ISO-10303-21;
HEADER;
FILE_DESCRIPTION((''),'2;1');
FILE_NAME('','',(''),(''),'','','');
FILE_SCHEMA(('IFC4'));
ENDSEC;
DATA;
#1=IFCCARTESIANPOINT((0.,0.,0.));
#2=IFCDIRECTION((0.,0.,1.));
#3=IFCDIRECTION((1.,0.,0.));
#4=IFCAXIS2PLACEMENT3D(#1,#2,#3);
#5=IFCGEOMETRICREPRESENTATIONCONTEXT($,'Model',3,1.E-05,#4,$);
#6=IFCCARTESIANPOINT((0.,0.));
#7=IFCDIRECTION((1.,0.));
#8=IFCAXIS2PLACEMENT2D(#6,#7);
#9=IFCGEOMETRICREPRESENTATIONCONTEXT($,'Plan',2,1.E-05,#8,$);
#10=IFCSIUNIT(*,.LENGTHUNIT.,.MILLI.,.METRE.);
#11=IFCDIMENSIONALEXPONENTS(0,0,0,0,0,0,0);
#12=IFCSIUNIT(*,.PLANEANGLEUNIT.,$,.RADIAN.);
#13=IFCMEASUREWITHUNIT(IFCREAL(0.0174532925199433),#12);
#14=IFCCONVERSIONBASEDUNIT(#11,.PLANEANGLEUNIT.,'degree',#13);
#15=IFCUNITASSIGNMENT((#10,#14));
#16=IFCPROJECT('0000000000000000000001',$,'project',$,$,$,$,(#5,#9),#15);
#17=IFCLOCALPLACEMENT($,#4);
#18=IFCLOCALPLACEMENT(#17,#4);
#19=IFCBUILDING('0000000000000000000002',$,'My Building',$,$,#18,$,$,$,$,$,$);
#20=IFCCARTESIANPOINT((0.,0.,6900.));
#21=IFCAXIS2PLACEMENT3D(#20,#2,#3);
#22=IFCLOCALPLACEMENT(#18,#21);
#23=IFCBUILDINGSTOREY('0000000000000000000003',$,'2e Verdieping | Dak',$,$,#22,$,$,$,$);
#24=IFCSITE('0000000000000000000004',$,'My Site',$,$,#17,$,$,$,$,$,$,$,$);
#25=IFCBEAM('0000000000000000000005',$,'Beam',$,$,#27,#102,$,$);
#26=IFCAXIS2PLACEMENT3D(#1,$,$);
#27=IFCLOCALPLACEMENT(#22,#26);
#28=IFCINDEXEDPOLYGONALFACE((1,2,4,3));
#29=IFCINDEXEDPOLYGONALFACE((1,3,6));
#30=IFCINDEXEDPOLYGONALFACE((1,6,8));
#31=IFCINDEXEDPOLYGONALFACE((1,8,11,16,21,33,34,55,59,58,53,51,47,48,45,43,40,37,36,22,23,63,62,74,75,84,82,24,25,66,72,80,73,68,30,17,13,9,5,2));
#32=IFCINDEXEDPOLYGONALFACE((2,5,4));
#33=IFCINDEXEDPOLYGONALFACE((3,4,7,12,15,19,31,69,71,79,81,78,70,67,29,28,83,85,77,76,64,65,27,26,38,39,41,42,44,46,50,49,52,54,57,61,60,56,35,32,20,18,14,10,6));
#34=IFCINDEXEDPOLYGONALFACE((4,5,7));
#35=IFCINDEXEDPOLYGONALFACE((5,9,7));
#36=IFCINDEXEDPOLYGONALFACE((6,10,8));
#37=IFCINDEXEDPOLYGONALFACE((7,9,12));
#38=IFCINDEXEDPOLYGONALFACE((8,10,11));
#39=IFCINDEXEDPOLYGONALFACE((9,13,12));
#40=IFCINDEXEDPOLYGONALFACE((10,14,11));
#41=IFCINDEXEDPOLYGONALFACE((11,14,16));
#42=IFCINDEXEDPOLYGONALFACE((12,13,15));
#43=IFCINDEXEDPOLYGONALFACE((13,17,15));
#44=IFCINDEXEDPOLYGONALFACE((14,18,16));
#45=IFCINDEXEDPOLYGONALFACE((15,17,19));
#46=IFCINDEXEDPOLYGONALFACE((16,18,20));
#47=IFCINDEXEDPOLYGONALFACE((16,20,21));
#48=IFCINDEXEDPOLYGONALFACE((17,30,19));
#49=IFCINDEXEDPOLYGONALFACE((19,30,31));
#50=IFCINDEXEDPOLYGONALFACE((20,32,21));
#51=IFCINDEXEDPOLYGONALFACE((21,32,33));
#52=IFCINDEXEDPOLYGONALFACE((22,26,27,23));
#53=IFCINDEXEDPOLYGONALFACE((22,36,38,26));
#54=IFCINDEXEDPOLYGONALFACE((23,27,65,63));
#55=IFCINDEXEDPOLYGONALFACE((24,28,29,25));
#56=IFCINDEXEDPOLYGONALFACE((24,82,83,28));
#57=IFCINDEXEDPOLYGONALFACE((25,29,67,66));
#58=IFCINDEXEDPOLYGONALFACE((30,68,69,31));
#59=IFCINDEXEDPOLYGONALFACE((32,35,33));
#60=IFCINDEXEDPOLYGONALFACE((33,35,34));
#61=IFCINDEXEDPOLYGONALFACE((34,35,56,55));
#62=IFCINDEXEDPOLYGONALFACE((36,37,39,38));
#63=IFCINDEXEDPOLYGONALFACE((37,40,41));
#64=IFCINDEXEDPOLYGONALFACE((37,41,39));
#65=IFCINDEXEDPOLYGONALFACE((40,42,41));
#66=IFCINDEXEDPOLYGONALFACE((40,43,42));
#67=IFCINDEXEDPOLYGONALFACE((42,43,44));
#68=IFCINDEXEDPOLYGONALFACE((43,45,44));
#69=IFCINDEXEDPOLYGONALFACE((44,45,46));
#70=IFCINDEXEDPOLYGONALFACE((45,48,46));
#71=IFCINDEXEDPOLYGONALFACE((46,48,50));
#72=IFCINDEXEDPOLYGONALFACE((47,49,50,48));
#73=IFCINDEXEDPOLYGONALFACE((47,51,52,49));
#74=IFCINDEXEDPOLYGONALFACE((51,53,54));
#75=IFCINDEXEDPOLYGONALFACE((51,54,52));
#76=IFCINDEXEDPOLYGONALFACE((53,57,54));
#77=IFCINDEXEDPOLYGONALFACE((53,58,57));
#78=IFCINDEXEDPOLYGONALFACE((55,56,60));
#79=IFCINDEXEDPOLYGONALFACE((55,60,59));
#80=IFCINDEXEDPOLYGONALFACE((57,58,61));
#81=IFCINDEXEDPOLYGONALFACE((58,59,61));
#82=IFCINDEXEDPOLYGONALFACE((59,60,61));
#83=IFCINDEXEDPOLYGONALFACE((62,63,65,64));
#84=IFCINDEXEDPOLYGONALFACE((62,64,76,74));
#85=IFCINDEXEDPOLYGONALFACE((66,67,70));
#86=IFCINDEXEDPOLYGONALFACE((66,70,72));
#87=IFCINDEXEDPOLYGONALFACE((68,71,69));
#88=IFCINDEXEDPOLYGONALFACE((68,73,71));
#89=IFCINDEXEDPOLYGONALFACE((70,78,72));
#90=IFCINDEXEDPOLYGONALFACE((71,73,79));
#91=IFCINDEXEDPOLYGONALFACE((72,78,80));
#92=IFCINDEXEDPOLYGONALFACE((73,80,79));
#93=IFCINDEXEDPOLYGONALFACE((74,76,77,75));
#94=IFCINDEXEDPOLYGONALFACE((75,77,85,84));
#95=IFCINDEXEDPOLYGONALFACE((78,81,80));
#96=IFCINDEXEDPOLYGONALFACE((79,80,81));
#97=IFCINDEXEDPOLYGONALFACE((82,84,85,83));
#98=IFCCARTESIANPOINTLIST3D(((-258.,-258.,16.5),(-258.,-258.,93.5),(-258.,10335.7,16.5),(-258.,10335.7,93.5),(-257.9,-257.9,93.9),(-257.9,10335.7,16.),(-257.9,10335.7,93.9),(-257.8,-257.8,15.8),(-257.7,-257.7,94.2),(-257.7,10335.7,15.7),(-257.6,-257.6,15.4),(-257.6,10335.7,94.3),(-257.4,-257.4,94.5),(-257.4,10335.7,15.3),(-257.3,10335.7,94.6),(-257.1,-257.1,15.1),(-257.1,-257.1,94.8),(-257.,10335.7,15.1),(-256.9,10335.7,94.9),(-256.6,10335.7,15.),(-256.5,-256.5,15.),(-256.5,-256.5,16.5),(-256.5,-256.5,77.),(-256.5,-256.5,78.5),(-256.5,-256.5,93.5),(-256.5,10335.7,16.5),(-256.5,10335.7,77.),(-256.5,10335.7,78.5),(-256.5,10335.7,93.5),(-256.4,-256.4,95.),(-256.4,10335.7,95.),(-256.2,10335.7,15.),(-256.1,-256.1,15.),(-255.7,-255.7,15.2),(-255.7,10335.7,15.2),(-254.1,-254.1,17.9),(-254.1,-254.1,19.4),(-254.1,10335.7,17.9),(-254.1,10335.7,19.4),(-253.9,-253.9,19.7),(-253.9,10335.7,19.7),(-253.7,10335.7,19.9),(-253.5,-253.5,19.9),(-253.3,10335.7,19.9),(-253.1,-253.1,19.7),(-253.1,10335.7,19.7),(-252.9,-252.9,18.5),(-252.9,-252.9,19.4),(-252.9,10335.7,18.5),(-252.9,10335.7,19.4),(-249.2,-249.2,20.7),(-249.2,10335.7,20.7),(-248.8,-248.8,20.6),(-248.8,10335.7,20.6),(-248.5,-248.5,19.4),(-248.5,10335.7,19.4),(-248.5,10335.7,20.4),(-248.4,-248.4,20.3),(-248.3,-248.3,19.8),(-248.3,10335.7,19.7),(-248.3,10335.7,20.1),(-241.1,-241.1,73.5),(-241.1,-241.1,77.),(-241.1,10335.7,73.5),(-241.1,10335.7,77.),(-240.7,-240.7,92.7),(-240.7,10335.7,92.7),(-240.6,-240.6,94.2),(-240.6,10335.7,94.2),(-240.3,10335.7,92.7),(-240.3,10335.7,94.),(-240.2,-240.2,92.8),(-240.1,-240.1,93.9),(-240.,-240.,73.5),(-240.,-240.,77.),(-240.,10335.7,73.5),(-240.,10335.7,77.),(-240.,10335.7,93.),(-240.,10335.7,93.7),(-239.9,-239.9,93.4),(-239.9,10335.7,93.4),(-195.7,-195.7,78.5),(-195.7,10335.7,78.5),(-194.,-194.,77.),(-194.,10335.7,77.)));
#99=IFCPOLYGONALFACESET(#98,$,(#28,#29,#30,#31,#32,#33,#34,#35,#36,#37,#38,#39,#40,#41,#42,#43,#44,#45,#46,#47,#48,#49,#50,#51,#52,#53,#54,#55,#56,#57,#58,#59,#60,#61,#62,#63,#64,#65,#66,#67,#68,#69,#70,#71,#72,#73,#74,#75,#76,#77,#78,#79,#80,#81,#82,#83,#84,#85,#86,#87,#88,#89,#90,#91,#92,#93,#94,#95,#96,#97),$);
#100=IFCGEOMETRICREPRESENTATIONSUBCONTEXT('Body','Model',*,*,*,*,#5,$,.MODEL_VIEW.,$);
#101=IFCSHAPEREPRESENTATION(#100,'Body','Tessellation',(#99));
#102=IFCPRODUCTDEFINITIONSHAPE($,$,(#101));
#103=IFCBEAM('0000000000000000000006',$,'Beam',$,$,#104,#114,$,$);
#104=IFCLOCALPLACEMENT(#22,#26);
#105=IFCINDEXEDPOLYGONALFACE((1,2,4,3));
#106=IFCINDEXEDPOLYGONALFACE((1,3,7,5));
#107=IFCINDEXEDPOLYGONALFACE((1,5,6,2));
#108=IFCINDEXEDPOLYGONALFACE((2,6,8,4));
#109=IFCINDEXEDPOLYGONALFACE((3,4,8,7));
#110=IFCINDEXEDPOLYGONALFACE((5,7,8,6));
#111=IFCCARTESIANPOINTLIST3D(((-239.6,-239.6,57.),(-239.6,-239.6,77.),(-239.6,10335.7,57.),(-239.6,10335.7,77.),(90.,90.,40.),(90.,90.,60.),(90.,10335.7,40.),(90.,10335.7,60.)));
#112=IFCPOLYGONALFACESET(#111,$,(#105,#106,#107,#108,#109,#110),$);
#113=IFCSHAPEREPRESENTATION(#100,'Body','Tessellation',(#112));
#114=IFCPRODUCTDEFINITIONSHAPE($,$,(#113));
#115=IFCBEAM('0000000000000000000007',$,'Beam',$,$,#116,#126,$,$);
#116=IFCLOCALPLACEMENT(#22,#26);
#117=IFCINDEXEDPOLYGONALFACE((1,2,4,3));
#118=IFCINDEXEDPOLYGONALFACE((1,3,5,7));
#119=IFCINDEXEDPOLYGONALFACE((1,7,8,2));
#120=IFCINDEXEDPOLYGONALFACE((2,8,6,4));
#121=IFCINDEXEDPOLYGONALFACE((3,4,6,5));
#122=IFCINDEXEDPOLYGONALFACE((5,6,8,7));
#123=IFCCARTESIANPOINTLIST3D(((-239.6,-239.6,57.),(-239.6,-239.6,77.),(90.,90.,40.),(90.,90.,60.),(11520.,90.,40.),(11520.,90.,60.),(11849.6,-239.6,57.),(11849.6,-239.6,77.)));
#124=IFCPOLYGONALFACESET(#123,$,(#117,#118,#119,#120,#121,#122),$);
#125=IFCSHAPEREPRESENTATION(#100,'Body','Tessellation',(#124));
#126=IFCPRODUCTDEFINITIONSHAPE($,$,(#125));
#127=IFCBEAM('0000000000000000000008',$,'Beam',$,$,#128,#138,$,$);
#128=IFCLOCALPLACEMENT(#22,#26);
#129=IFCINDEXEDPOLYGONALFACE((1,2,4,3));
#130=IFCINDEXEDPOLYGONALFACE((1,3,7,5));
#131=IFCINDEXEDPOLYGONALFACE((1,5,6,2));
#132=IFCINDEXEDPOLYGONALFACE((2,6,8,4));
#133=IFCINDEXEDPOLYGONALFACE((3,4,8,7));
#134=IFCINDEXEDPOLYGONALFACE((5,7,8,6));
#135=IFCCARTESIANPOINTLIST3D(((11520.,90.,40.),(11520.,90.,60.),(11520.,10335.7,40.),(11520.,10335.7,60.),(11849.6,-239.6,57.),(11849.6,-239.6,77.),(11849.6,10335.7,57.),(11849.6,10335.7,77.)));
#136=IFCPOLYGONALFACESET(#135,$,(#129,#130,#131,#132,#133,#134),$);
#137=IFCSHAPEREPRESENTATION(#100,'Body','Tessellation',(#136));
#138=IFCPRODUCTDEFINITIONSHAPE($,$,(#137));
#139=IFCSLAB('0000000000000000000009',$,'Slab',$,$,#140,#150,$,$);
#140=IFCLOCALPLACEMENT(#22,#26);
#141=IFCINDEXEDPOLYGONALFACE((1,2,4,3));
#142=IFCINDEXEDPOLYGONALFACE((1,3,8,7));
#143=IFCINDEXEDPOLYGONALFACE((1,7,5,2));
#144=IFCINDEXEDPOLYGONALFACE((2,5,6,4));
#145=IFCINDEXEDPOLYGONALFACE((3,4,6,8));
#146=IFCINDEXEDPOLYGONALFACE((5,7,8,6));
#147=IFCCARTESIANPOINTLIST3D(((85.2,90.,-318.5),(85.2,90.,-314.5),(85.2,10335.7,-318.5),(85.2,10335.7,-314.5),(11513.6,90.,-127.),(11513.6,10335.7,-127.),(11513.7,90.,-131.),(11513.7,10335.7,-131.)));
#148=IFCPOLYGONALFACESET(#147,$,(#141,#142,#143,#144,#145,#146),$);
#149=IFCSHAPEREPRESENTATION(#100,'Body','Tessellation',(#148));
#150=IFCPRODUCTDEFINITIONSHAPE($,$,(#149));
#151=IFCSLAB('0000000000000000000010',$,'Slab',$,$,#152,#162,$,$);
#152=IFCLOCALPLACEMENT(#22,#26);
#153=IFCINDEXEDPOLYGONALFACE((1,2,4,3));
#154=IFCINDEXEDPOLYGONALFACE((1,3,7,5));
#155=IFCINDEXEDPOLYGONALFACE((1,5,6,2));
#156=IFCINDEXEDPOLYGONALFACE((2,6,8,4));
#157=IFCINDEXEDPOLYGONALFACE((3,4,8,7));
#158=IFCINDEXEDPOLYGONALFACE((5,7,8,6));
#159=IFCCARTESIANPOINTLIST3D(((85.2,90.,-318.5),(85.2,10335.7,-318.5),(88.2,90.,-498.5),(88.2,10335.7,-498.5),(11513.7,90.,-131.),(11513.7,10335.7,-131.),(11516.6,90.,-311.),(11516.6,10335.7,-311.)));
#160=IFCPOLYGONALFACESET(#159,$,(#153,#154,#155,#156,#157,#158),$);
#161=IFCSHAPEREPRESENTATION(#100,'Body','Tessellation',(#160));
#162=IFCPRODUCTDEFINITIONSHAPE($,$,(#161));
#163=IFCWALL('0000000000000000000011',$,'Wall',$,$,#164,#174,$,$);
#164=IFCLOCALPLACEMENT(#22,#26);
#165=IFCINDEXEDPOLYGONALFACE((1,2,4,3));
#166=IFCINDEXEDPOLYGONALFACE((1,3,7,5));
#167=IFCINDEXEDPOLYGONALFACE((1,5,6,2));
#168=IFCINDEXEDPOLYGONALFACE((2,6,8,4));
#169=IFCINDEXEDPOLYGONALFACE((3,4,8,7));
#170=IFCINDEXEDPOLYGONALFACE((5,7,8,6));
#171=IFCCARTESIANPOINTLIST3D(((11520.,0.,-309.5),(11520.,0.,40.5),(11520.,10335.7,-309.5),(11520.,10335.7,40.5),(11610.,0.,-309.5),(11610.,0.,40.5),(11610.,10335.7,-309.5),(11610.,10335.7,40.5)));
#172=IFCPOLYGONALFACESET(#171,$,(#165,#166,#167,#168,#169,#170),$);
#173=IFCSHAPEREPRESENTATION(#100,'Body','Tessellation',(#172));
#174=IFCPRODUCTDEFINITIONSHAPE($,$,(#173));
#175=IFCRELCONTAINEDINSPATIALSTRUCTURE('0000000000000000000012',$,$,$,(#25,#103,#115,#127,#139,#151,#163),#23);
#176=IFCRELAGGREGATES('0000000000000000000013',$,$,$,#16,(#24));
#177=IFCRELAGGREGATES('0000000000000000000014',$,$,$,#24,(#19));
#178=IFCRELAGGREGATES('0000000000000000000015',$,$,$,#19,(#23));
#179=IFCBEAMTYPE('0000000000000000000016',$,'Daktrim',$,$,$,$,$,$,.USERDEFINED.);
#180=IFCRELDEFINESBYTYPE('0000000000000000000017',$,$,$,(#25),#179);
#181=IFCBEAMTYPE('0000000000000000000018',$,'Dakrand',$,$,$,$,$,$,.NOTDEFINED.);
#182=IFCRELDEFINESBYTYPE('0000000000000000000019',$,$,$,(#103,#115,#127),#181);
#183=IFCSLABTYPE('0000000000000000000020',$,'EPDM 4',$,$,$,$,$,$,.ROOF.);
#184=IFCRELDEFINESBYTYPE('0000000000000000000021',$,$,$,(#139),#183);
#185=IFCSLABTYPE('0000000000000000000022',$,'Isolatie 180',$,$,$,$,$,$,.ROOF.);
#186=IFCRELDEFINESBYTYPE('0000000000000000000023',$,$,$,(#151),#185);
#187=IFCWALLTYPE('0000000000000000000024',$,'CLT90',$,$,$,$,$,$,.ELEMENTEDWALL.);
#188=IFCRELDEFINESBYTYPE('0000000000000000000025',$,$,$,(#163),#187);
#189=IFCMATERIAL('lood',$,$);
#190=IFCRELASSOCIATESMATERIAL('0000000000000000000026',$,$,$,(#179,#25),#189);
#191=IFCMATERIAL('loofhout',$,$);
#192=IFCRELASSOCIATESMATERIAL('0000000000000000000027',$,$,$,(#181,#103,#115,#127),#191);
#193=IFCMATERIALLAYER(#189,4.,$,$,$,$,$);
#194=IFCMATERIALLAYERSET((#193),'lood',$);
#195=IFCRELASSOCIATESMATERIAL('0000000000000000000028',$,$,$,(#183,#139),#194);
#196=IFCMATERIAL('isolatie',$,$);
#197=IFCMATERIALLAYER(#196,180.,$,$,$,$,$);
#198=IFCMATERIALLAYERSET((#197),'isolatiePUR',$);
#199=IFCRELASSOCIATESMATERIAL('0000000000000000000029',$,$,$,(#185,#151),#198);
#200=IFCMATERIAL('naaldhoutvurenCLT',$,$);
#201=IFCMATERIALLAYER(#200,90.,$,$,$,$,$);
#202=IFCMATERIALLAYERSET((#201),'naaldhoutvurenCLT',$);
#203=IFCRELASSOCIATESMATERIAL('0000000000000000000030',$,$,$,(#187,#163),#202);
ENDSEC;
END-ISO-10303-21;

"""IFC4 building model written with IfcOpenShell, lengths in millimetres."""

from ifc_helpers import new_model, entity, si_unit, converted_unit, frame, origin_with_axes, origin_2d_with_axis, place, context, subcontext, project, spatial, line, arc, indexed_curve, outline, extrude, clip, halfspace, material, layer, layer_set, layer_usage, material_profile, profile_set, profile_usage, type_object, element, save


model = new_model("IFC4")

# Units and contexts
model_context = context("Model", 3, precision=1e-05, world=origin_with_axes())
plan_context = context("Plan", 2, precision=1e-05, world=origin_2d_with_axis())
body_context = subcontext(model_context, "Body", "Model", "MODEL_VIEW")
ifc_project = project(units=[si_unit("LENGTHUNIT", "METRE", prefix="MILLI"), converted_unit("PLANEANGLEUNIT", "degree", entity("IfcReal", 0.0174532925199433), si_unit("PLANEANGLEUNIT", "RADIAN"), dimensions=[0, 0, 0, 0, 0, 0, 0])], contexts=[model_context, plan_context])

# Site, building, storey
site_placement = place(None, origin_with_axes())
site = spatial("IfcSite", under=ifc_project, at=site_placement, Name="My Site")
building_placement = place(site_placement, origin_with_axes())
building = spatial("IfcBuilding", under=site, at=building_placement, Name="My Building")
storey_placement = place(building_placement, frame((0.0, 0.0, 6900.0), z_axis=(0.0, 0.0, 1.0), x_axis=(1.0, 0.0, 0.0)))
storey = spatial("IfcBuildingStorey", under=building, at=storey_placement, Name="2e Verdieping | Dak")

# Beams
ifc_material_1 = material(Name="lood")
ifc_material_profile_1 = material_profile(ifc_material_1, outline(indexed_curve([(12.9, -58.5), (12.9, -57.6), (13.5, -57.1), (14.1, -57.6), (14.1, -59.1), (16.5, -60.5), (16.5, 0.0), (1.1, 0.0), (1.1, -3.5), (0.0, -3.5), (0.0, 0.0), (-46.0, 0.0), (-44.3, 1.5), (16.5, 1.5), (16.5, 16.5), (0.7, 15.7), (-0.1, 16.4), (0.6, 17.2), (16.4, 18.0), (17.6, 17.3), (18.0, 16.5), (18.0, -60.5), (17.2, -61.8), (15.8, -61.8), (8.5, -57.6), (8.4, -56.7), (9.2, -56.3)], segments=[line(10, 9), line(9, 8), line(8, 7), line(7, 6), line(6, 5), line(5, 4), arc(4, 3, 2), line(2, 1), line(1, 27), arc(27, 26, 25), line(25, 24), arc(24, 23, 22), line(22, 21), arc(21, 20, 19), line(19, 18), arc(18, 17, 16), line(16, 15), line(15, 14), line(14, 13), line(13, 12), line(12, 11), line(11, 10)], self_intersect=False)))
ifc_profile_set_1 = profile_set([ifc_material_profile_1], Name="lood")
beam_type_1 = type_object("IfcBeamType", Name="Daktrim", PredefinedType="USERDEFINED", material=ifc_profile_set_1)
ifc_profile_usage_1 = profile_usage(ifc_profile_set_1, cardinal=5)
beam_1_placement = place(storey_placement, frame((-240.0, -258.0, 77.0), z_axis=(0.0, 1.0, 0.0), x_axis=(-1.0, 0.0, 0.0)))
element("IfcBeam", 1, at=beam_1_placement, inside=storey, type_object=beam_type_1, material=ifc_profile_usage_1, Name="Beam", context=body_context, shape_type="Clipping", body=[
    clip(extrude(outline(indexed_curve([(12.9, -58.5), (12.9, -57.6), (13.5, -57.1), (14.1, -57.6), (14.1, -59.1), (16.5, -60.5), (16.5, 0.0), (1.1, 0.0), (1.1, -3.5), (0.0, -3.5), (0.0, 0.0), (-46.0, 0.0), (-44.3, 1.5), (16.5, 1.5), (16.5, 16.5), (0.7, 15.7), (-0.1, 16.4), (0.6, 17.2), (16.4, 18.0), (17.6, 17.3), (18.0, 16.5), (18.0, -60.5), (17.2, -61.8), (15.8, -61.8), (8.5, -57.6), (8.4, -56.7), (9.2, -56.3)], segments=[line(10, 9), line(9, 8), line(8, 7), line(7, 6), line(6, 5), line(5, 4), arc(4, 3, 2), line(2, 1), line(1, 27), arc(27, 26, 25), line(25, 24), arc(24, 23, 22), line(22, 21), arc(21, 20, 19), line(19, 18), arc(18, 17, 16), line(16, 15), line(15, 14), line(14, 13), line(13, 12), line(12, 11), line(11, 10)], self_intersect=False)), origin_with_axes(), (0.0, 0.0, 1.0), 10593.7), halfspace(frame((18.0, -6977.0, 0.0), z_axis=(-0.707107, 0.0, -0.707107), x_axis=(0.0, 1.0, 0.0)), False)),
])
ifc_material_2 = material(Name="loofhout")
ifc_material_profile_2 = material_profile(ifc_material_2, outline(indexed_curve([(329.6, 37.0), (329.6, 17.0), (0.0, 0.0), (0.0, 20.0)], segments=[line(3, 2), line(2, 1), line(1, 4), line(4, 3)], self_intersect=False)))
ifc_profile_set_2 = profile_set([ifc_material_profile_2], Name="loofhout")
ifc_profile_usage_2 = profile_usage(ifc_profile_set_2)
beam_type_2 = type_object("IfcBeamType", Name="Dakrand", PredefinedType="NOTDEFINED", material=ifc_profile_set_2)
beam_2_placement = place(storey_placement, frame((90.0, -239.6, 40.0), z_axis=(0.0, 1.0, 0.0), x_axis=(-1.0, 0.0, 0.0)))
element("IfcBeam", 2, at=beam_2_placement, inside=storey, type_object=beam_type_2, material=ifc_profile_usage_2, Name="Beam", context=body_context, shape_type="Clipping", body=[
    clip(extrude(outline(indexed_curve([(329.6, 37.0), (329.6, 17.0), (0.0, 0.0), (0.0, 20.0)], segments=[line(3, 2), line(2, 1), line(1, 4), line(4, 3)], self_intersect=False)), origin_with_axes(), (0.0, 0.0, 1.0), 10575.3), halfspace(frame((329.6, -6940.0, 0.0), z_axis=(-0.707107, 0.0, -0.707107), x_axis=(0.0, 1.0, 0.0)), False)),
])
ifc_profile_usage_3 = profile_usage(ifc_profile_set_2)
beam_3_placement = place(storey_placement, frame((11849.6, 90.0, 40.0), z_axis=(-1.0, 0.0, 0.0), x_axis=(0.0, -1.0, 0.0)))
element("IfcBeam", 3, at=beam_3_placement, inside=storey, type_object=beam_type_2, material=ifc_profile_usage_3, Name="Beam", context=body_context, shape_type="Clipping", body=[
    clip(clip(extrude(outline(indexed_curve([(329.6, 37.0), (329.6, 17.0), (0.0, 0.0), (0.0, 20.0)], segments=[line(3, 2), line(2, 1), line(1, 4), line(4, 3)], self_intersect=False)), origin_with_axes(), (0.0, 0.0, 1.0), 12089.1), halfspace(frame((329.6, -6940.0, 12089.1), z_axis=(-0.707107, 0.0, 0.707107), x_axis=(0.0, 1.0, 0.0)), False)), halfspace(frame((329.6, -6940.0, 0.0), z_axis=(-0.707107, 0.0, -0.707106), x_axis=(0.0, 1.0, 0.0)), False)),
])
ifc_profile_usage_4 = profile_usage(ifc_profile_set_2)
beam_4_placement = place(storey_placement, frame((11520.0, 10335.7, 40.0), z_axis=(0.0, -1.0, 0.0), x_axis=(1.0, 0.0, 0.0)))
element("IfcBeam", 4, at=beam_4_placement, inside=storey, type_object=beam_type_2, material=ifc_profile_usage_4, Name="Beam", context=body_context, shape_type="Clipping", body=[
    clip(extrude(outline(indexed_curve([(329.6, 37.0), (329.6, 17.0), (0.0, 0.0), (0.0, 20.0)], segments=[line(3, 2), line(2, 1), line(1, 4), line(4, 3)], self_intersect=False)), origin_with_axes(), (0.0, 0.0, 1.0), 10575.3), halfspace(frame((329.6, -6940.0, 10575.3), z_axis=(-0.707106, 0.0, 0.707107), x_axis=(0.0, 1.0, 0.0)), False)),
])

# Slabs
ifc_layer_1 = layer(ifc_material_1, 4.0)
ifc_layer_set_1 = layer_set([ifc_layer_1], Name="lood")
ifc_layer_usage_1 = layer_usage(ifc_layer_set_1, "AXIS3", "POSITIVE", 0.0)
slab_type_1 = type_object("IfcSlabType", Name="EPDM 4", PredefinedType="ROOF", material=ifc_layer_set_1)
slab_1_placement = place(storey_placement, frame((11513.7, 90.0, -131.0), z_axis=(-0.016405, 0.0, 0.999865), x_axis=(0.999865, 0.0, 0.016405)))
element("IfcSlab", 5, at=slab_1_placement, inside=storey, type_object=slab_type_1, material=ifc_layer_usage_1, Name="Slab", context=body_context, shape_type="SweptSolid", body=[
    extrude(outline(indexed_curve([(-11430.0, 0.0), (-11430.0, 10245.7), (0.0, 10245.7), (0.0, 0.0)], segments=[line(3, 2), line(2, 1), line(1, 4), line(4, 3)], self_intersect=False)), None, (0.0, 0.0, 1.0), 4.0),
])
ifc_material_3 = material(Name="isolatie")
ifc_layer_2 = layer(ifc_material_3, 180.0)
ifc_layer_set_2 = layer_set([ifc_layer_2], Name="isolatiePUR")
ifc_layer_usage_2 = layer_usage(ifc_layer_set_2, "AXIS3", "POSITIVE", 0.0)
slab_type_2 = type_object("IfcSlabType", Name="Isolatie 180", PredefinedType="ROOF", material=ifc_layer_set_2)
slab_2_placement = place(storey_placement, frame((11516.6, 90.0, -311.0), z_axis=(-0.016405, 0.0, 0.999865), x_axis=(0.999865, 0.0, 0.016405)))
element("IfcSlab", 6, at=slab_2_placement, inside=storey, type_object=slab_type_2, material=ifc_layer_usage_2, Name="Slab", context=body_context, shape_type="SweptSolid", body=[
    extrude(outline(indexed_curve([(0.0, 10245.7), (0.0, 0.0), (-11430.0, 0.0), (-11430.0, 10245.7)], segments=[line(4, 1), line(1, 2), line(2, 3), line(3, 4)], self_intersect=False)), None, (0.0, 0.0, 1.0), 180.0),
])
ifc_material_4 = material(Name="naaldhoutvurenCLT")

# Wall
ifc_layer_3 = layer(ifc_material_4, 90.0)
ifc_layer_set_3 = layer_set([ifc_layer_3], Name="naaldhoutvurenCLT")
ifc_layer_usage_3 = layer_usage(ifc_layer_set_3, "AXIS2", "POSITIVE", 0.0)
wall_type = type_object("IfcWallType", Name="CLT90", PredefinedType="ELEMENTEDWALL", material=ifc_layer_set_3)
wall_1_placement = place(storey_placement, frame((11610.0, 0.0, -309.5), z_axis=(0.0, 0.0, 1.0), x_axis=(0.0, 1.0, 0.0)))
element("IfcWall", 7, at=wall_1_placement, inside=storey, type_object=wall_type, material=ifc_layer_usage_3, Name="Wall", context=body_context, shape_type="SweptSolid", body=[
    extrude(outline(indexed_curve([(0.0, 0.0), (0.0, 90.0), (10335.7, 90.0), (10335.7, 0.0), (0.0, 0.0)], self_intersect=False)), origin_with_axes(), (0.0, 0.0, 1.0), 350.0),
])

save(model, "model.ifc")
